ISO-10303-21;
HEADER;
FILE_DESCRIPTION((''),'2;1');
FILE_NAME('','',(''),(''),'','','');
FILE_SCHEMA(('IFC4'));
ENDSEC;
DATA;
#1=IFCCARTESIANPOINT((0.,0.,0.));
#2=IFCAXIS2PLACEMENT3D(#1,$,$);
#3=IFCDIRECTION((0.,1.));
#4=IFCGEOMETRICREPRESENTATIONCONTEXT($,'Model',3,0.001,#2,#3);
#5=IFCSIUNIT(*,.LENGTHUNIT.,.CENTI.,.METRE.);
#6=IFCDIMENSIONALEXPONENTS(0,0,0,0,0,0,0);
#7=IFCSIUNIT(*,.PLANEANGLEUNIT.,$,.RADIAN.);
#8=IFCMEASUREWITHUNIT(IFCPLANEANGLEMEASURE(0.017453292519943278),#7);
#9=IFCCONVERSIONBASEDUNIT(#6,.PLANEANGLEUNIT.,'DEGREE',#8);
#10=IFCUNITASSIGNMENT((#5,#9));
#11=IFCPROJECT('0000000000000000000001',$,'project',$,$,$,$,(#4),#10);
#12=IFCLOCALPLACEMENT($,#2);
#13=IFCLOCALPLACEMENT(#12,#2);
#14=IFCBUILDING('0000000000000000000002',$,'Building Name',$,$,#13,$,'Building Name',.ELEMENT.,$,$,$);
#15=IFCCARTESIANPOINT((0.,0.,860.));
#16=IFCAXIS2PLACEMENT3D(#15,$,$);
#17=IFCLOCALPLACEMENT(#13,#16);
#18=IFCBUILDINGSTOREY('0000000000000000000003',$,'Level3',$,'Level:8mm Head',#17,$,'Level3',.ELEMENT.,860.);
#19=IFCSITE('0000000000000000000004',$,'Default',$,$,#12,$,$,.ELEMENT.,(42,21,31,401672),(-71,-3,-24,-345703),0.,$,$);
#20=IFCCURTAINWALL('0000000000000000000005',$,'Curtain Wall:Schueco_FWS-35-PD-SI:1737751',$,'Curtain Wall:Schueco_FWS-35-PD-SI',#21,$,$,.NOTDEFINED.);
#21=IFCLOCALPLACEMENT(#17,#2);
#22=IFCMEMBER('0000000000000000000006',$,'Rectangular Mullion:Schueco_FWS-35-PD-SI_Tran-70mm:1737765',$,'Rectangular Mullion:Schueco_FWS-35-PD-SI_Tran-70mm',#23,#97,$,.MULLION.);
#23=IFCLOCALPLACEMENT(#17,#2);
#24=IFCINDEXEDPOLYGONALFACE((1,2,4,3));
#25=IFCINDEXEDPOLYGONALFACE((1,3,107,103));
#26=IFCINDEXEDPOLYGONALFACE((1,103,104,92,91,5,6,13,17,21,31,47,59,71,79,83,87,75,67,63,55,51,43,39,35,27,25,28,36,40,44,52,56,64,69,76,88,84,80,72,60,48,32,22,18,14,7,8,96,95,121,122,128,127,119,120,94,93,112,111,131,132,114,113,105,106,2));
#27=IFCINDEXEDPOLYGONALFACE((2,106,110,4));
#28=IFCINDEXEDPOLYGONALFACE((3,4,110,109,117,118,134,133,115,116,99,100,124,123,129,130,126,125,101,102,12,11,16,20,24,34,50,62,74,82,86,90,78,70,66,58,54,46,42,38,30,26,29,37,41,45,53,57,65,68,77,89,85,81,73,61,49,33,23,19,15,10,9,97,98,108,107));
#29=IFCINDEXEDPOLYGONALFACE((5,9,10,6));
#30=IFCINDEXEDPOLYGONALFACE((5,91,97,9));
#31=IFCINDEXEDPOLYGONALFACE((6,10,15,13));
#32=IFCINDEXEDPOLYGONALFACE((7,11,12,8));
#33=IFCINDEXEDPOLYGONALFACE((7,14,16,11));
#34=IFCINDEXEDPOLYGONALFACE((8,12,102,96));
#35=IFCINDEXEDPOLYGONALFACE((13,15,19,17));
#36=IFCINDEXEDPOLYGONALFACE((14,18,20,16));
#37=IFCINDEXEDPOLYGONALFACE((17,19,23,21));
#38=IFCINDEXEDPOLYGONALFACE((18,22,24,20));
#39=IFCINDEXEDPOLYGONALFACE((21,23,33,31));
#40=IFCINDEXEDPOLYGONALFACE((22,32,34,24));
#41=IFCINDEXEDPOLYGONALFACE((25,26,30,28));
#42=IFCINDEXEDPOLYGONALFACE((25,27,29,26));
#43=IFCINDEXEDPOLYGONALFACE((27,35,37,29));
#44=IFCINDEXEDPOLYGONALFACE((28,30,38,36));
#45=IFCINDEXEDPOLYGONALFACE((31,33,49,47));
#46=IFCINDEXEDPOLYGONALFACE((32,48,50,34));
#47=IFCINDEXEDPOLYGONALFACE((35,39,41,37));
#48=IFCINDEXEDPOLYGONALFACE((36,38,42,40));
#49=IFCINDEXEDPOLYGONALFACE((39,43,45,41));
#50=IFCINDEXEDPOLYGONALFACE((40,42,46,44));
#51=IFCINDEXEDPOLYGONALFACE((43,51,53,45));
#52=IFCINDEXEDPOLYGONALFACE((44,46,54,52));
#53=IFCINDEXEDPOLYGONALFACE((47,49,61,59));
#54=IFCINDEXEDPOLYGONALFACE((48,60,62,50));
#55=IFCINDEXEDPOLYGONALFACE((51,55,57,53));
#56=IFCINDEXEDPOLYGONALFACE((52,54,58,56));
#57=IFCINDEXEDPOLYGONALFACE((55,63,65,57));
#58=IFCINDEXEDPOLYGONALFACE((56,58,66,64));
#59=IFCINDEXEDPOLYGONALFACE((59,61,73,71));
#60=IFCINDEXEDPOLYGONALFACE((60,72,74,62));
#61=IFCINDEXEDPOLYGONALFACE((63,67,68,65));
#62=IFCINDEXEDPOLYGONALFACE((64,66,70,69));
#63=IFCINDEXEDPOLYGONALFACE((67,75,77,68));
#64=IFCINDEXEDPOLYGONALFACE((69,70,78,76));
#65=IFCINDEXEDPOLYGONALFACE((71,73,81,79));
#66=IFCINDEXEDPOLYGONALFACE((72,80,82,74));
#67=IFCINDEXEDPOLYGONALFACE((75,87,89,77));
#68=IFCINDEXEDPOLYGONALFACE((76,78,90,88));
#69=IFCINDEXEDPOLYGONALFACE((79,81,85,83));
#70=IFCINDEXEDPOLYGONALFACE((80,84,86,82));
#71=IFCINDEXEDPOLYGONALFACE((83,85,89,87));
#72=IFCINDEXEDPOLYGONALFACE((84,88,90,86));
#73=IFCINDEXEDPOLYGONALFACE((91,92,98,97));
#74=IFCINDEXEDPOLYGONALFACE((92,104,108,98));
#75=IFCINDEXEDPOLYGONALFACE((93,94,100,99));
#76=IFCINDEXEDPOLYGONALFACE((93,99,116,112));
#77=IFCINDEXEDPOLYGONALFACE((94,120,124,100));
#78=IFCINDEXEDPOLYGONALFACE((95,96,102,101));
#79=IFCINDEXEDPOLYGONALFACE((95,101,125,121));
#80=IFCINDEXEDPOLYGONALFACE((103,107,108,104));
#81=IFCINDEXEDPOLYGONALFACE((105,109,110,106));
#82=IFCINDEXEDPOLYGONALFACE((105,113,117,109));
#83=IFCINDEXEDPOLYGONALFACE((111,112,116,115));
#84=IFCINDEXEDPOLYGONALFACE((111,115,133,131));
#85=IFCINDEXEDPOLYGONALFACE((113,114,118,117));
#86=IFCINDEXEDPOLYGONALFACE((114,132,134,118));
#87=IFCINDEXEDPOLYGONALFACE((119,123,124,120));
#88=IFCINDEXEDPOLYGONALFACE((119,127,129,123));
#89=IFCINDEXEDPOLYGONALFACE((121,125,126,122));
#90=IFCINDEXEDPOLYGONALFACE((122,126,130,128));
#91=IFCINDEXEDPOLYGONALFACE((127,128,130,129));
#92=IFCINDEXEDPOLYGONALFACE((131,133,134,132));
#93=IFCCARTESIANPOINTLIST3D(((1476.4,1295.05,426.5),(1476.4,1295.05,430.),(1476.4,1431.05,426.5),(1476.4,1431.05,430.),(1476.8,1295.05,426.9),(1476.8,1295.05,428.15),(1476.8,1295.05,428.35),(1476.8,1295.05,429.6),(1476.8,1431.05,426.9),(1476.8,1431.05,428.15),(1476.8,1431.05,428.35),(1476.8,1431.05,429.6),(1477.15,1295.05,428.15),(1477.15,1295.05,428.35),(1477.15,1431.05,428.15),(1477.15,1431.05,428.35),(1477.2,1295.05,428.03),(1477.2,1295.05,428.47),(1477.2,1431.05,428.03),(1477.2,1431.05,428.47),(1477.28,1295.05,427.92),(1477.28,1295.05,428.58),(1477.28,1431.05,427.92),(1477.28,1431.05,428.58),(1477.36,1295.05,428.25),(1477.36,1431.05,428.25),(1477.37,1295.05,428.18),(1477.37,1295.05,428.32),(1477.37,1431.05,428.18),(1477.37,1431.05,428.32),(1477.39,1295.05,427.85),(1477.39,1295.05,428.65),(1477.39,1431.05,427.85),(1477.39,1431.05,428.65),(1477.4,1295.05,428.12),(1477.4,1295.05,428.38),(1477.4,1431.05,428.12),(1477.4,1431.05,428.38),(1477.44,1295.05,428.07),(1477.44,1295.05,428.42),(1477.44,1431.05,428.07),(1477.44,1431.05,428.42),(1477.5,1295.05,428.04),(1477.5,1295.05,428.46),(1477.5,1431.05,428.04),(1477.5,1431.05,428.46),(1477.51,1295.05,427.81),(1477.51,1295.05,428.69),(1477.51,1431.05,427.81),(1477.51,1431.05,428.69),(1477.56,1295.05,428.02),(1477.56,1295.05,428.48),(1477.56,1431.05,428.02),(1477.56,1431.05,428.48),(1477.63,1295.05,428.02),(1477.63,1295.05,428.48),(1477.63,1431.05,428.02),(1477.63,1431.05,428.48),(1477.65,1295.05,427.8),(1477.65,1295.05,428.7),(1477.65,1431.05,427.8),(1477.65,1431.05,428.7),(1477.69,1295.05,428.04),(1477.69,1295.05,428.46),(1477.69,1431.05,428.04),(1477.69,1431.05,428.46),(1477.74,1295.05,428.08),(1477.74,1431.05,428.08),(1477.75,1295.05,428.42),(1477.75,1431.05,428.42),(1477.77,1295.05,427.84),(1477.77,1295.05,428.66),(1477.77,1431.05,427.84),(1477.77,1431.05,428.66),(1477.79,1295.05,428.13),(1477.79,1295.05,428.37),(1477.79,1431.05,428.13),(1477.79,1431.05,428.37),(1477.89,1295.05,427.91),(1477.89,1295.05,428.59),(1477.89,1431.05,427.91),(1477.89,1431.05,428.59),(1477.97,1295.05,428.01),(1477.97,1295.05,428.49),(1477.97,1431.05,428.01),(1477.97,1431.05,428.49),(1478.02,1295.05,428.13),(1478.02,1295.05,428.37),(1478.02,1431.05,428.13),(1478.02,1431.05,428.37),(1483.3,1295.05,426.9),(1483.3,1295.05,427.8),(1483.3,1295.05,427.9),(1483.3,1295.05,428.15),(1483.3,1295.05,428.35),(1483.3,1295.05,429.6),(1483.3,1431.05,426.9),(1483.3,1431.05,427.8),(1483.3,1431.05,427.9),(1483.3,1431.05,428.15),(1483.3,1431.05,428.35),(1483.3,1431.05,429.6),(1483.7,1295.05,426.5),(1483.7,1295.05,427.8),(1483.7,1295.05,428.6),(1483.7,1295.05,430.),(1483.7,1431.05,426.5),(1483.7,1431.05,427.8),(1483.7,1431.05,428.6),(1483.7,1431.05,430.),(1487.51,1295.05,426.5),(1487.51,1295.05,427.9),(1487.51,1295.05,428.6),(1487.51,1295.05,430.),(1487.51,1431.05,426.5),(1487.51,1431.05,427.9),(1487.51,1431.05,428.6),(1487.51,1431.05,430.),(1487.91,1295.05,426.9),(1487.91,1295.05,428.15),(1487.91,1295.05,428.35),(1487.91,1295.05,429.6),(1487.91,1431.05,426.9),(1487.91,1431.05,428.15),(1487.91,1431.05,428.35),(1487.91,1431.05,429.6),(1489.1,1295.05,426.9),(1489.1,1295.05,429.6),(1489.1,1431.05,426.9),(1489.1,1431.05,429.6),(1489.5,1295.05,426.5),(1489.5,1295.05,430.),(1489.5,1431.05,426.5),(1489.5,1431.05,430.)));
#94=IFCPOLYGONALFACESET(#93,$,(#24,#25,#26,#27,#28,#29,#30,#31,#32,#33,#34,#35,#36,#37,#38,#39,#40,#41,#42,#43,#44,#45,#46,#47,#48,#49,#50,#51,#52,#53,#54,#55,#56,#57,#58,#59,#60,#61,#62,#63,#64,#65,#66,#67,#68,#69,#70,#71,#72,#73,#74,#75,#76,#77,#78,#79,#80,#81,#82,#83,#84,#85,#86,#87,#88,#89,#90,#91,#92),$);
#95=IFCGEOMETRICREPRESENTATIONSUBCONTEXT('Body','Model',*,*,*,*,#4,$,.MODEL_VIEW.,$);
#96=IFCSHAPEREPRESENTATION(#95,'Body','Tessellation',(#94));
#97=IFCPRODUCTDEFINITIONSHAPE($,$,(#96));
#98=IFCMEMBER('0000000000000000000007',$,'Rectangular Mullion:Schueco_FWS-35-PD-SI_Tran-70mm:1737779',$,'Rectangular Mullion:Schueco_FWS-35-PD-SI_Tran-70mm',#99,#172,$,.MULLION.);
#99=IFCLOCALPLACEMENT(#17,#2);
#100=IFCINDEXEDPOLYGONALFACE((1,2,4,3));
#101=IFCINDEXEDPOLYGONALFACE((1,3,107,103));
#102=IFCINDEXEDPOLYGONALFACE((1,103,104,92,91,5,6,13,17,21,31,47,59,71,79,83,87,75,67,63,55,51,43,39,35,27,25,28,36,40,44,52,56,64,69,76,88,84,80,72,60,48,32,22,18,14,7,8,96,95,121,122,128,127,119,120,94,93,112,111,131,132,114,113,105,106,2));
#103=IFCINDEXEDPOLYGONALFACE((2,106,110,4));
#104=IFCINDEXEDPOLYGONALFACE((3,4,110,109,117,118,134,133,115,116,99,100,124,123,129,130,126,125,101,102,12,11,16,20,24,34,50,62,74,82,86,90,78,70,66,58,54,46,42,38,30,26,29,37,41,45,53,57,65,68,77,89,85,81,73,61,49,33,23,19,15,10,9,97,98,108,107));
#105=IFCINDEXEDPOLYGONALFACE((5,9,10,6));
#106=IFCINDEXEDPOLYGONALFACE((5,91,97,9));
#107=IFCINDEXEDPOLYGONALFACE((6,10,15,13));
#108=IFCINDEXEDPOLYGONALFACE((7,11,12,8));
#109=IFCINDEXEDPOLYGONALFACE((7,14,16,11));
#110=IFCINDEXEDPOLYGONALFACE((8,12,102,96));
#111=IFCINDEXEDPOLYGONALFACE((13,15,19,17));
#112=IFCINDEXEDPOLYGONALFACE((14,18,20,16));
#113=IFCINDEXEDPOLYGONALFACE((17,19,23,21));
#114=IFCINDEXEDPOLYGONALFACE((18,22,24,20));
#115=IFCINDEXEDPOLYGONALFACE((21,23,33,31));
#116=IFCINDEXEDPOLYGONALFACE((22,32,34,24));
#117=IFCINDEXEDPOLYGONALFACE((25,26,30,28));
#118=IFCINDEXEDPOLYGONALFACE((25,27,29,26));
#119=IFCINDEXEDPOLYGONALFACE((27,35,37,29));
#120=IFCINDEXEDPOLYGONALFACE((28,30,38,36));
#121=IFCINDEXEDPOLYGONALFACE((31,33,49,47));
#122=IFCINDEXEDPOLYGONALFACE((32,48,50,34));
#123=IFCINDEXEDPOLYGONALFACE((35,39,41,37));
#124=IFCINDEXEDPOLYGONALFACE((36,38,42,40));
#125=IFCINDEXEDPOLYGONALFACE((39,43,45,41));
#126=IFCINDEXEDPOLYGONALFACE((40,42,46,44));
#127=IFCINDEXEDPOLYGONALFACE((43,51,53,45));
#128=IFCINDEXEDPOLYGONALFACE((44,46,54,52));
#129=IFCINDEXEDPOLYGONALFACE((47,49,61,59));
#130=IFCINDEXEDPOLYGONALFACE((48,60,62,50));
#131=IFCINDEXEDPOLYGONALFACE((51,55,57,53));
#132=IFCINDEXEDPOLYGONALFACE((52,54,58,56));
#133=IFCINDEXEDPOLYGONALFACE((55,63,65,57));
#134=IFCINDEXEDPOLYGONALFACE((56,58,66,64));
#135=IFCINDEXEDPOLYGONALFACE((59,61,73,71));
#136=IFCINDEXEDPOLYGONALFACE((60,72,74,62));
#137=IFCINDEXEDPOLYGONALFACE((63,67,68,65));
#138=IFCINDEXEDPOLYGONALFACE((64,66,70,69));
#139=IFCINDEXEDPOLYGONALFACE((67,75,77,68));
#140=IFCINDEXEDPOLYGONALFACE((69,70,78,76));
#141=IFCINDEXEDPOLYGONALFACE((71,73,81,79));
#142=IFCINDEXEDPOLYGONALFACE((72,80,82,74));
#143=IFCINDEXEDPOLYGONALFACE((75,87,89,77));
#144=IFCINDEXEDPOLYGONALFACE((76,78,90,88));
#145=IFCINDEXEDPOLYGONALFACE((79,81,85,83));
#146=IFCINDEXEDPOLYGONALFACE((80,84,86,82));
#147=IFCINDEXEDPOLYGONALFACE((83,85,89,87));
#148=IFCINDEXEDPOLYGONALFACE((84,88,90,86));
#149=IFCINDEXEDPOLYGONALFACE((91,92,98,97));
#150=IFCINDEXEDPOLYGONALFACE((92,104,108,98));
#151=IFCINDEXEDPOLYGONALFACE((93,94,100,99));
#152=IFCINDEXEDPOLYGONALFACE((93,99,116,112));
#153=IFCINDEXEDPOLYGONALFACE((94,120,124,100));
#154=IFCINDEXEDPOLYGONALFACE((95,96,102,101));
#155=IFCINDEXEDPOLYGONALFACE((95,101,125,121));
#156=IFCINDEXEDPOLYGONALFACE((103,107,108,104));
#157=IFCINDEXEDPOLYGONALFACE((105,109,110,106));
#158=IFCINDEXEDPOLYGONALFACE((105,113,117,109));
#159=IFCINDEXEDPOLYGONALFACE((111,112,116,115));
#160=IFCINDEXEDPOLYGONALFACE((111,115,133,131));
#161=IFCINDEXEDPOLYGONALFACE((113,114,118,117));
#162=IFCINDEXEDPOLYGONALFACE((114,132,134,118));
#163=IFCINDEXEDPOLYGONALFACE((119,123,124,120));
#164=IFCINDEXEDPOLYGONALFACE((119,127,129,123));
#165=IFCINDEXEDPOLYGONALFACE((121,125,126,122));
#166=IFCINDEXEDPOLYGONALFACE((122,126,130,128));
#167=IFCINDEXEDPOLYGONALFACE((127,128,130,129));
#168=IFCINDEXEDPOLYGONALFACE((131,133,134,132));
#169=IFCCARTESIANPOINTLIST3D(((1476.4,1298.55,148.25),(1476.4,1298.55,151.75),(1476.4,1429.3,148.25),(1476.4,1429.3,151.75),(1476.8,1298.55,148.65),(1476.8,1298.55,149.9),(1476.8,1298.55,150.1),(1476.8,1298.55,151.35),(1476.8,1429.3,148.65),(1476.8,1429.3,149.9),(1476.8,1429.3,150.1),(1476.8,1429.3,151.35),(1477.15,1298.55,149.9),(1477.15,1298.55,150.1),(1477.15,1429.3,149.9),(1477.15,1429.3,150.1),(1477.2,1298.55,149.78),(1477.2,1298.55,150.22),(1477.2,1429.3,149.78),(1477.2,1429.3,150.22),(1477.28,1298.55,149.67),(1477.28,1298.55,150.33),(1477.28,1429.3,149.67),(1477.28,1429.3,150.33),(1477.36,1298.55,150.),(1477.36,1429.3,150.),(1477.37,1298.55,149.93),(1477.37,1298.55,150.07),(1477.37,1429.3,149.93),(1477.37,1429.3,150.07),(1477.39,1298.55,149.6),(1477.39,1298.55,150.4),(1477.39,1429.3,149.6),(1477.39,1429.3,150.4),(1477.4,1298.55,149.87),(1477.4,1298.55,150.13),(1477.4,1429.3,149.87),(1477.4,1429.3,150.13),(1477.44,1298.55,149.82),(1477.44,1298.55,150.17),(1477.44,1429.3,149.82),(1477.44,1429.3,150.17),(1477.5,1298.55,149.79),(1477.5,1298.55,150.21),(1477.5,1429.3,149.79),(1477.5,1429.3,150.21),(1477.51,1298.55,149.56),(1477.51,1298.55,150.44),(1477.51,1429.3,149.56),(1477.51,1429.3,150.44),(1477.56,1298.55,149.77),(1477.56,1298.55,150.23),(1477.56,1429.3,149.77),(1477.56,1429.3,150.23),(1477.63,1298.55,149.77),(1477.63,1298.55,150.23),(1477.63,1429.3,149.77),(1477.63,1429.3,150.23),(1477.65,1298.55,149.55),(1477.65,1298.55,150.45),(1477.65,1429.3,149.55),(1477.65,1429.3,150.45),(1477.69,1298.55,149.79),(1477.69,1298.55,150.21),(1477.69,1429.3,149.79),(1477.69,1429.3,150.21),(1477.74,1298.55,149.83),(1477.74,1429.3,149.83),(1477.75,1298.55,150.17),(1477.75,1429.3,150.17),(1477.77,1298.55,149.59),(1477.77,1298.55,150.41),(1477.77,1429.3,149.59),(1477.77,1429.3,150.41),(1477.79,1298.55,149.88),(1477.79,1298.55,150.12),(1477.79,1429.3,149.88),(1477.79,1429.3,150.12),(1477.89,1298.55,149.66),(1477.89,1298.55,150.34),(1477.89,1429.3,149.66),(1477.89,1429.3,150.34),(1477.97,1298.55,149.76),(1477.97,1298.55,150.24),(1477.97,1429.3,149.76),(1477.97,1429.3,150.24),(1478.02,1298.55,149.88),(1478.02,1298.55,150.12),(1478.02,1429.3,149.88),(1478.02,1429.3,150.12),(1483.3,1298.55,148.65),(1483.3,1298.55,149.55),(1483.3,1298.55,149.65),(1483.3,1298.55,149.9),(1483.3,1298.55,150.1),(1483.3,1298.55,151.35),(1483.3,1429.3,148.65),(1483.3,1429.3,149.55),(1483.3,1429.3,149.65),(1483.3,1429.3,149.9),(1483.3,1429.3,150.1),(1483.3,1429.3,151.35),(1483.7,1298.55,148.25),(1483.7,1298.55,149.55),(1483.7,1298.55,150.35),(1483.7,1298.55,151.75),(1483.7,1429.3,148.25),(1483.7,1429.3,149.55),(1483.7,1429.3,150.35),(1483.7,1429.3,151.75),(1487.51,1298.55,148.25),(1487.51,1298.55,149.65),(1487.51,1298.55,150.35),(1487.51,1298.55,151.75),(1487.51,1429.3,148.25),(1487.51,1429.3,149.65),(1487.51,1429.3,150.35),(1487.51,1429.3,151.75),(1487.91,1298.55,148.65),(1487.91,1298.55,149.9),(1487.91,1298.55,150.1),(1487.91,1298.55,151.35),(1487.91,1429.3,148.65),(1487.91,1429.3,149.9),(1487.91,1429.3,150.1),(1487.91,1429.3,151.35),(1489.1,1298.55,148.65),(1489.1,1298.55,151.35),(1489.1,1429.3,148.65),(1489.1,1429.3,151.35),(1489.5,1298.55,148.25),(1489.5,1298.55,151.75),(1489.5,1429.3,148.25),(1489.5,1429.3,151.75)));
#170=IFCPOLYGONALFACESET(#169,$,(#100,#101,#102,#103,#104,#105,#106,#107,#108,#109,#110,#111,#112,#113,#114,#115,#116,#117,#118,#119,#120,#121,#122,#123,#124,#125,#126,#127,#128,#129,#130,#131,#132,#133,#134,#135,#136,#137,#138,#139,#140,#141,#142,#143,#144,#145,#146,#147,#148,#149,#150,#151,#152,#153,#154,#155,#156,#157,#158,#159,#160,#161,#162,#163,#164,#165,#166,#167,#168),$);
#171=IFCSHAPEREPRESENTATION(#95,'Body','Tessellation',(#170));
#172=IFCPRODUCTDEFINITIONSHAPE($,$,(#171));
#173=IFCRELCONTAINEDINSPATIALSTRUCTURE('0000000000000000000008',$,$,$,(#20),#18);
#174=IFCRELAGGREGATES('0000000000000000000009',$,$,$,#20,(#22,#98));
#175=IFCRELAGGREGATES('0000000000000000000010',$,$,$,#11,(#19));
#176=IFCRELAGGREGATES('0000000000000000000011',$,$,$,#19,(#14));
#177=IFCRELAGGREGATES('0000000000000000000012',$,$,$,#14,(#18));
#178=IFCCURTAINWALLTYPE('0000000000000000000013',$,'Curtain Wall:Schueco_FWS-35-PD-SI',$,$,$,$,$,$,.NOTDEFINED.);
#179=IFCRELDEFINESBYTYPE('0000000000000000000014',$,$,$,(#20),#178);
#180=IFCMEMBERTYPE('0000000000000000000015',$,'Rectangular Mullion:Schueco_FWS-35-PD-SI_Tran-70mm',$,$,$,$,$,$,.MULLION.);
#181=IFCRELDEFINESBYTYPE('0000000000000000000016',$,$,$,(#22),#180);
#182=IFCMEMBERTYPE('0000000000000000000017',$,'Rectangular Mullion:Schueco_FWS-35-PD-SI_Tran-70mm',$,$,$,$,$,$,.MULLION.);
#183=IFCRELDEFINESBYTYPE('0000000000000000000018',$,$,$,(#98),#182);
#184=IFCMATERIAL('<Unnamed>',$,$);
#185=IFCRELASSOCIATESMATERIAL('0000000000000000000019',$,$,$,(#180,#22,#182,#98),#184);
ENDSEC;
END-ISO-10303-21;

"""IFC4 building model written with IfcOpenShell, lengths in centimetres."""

from ifc_helpers import new_model, entity, si_unit, converted_unit, direction, frame, origin, place, context, subcontext, project, spatial, line, arc, indexed_curve, outline, extrude, source, transform, mapped, material, type_object, type_shapes, element, aggregate, save


model = new_model("IFC4")

# Units and contexts
model_context = context("Model", 3, precision=0.001, world=origin(), true_north=direction((0.0, 1.0)))
body_context = subcontext(model_context, "Body", "Model", "MODEL_VIEW")
ifc_project = project(units=[si_unit("LENGTHUNIT", "METRE", prefix="CENTI"), converted_unit("PLANEANGLEUNIT", "DEGREE", entity("IfcPlaneAngleMeasure", 0.017453292519943278), si_unit("PLANEANGLEUNIT", "RADIAN"), dimensions=[0, 0, 0, 0, 0, 0, 0])], contexts=[model_context])

# Site, building, storey
site_placement = place(None, origin())
site = spatial("IfcSite", under=ifc_project, at=site_placement, Name="Default", CompositionType="ELEMENT", RefLatitude=(42, 21, 31, 401672), RefLongitude=(-71, -3, -24, -345703), RefElevation=0.0)
building_placement = place(site_placement, origin())
building = spatial("IfcBuilding", under=site, at=building_placement, Name="Building Name", LongName="Building Name", CompositionType="ELEMENT")
storey_placement = place(building_placement, frame((0.0, 0.0, 860.0)))
storey = spatial("IfcBuildingStorey", under=building, at=storey_placement, Name="Level3", ObjectType="Level:8mm Head", LongName="Level3", CompositionType="ELEMENT", Elevation=860.0)

# Curtain wall, members
curtain_wall_type = type_object("IfcCurtainWallType", Name="Curtain Wall:Schueco_FWS-35-PD-SI", PredefinedType="NOTDEFINED")
curtain_wall_placement = place(storey_placement, frame((0.0, 0.0, -860.0)))
curtain_wall = element("IfcCurtainWall", 1, at=curtain_wall_placement, inside=storey, type_object=curtain_wall_type, Name="Curtain Wall:Schueco_FWS-35-PD-SI:1737751", ObjectType="Curtain Wall:Schueco_FWS-35-PD-SI", PredefinedType="NOTDEFINED")
ifc_material_1 = material(Name="<Unnamed>")
member_type_1 = type_object("IfcMemberType", Name="Rectangular Mullion:Schueco_FWS-35-PD-SI_Tran-70mm", PredefinedType="MULLION", material=ifc_material_1)
shared_shape_1 = source(origin(), body_context, "Body", "SweptSolid", [
    extrude(outline(indexed_curve([(-1.78, -6.52), (1.72, -6.52), (1.72, 0.78), (0.42, 0.78), (0.42, 0.38), (1.32, 0.38), (1.32, -6.12), (0.07, -6.12), (0.07, -5.77), (0.42, -5.34), (0.09, -4.9), (0.09, -5.14), (-0.03, -5.56), (-0.15, -5.14), (-0.15, -4.9), (-0.48, -5.34), (-0.13, -5.77), (-0.13, -6.12), (-1.38, -6.12), (-1.38, 0.38), (-0.13, 0.38), (-0.13, 4.99), (-1.38, 4.99), (-1.38, 6.18), (1.32, 6.18), (1.32, 4.99), (0.07, 4.99), (0.07, 0.38), (0.32, 0.38), (0.32, 4.59), (1.72, 4.59), (1.72, 6.58), (-1.78, 6.58), (-1.78, 4.59), (-0.38, 4.59), (-0.38, 0.78), (-1.78, 0.78)], segments=[line(1, 2, 3, 4, 5, 6, 7, 8, 9), arc(9, 10, 11), line(11, 12), arc(12, 13, 14), line(14, 15), arc(15, 16, 17), line(17, 18, 19, 20, 21, 22, 23, 24, 25, 26, 27, 28, 29, 30, 31, 32, 33, 34, 35, 36, 37, 1)], self_intersect=False)), frame((-1.78, 4.58, -136.0), z_axis=(0.0, 0.0, 1.0), x_axis=(-1.0, 0.0, 0.0)), (0.0, 0.0, 1.0), 136.0),
])
type_shapes(member_type_1, [shared_shape_1])
member_1_placement = place(curtain_wall_placement, frame((1487.5, 1295.05, 1290.0), z_axis=(0.0, -1.0, 0.0), x_axis=(0.0, 0.0, 1.0)))
member_1 = element("IfcMember", 2, at=member_1_placement, type_object=member_type_1, material=ifc_material_1, Name="Rectangular Mullion:Schueco_FWS-35-PD-SI_Tran-70mm:1737765", ObjectType="Rectangular Mullion:Schueco_FWS-35-PD-SI_Tran-70mm", PredefinedType="MULLION", context=body_context, shape_type="MappedRepresentation", body=[
    mapped(shared_shape_1, transform((0.0, 0.0, 0.0), scale=1.0)),
])
member_type_2 = type_object("IfcMemberType", Name="Rectangular Mullion:Schueco_FWS-35-PD-SI_Tran-70mm", PredefinedType="MULLION", material=ifc_material_1)
shared_shape_2 = source(origin(), body_context, "Body", "SweptSolid", [
    extrude(outline(indexed_curve([(-1.78, -6.52), (1.72, -6.52), (1.72, 0.78), (0.42, 0.78), (0.42, 0.38), (1.32, 0.38), (1.32, -6.12), (0.07, -6.12), (0.07, -5.77), (0.42, -5.34), (0.09, -4.9), (0.09, -5.14), (-0.03, -5.56), (-0.15, -5.14), (-0.15, -4.9), (-0.48, -5.34), (-0.13, -5.77), (-0.13, -6.12), (-1.38, -6.12), (-1.38, 0.38), (-0.13, 0.38), (-0.13, 4.99), (-1.38, 4.99), (-1.38, 6.18), (1.32, 6.18), (1.32, 4.99), (0.07, 4.99), (0.07, 0.38), (0.32, 0.38), (0.32, 4.59), (1.72, 4.59), (1.72, 6.58), (-1.78, 6.58), (-1.78, 4.59), (-0.38, 4.59), (-0.38, 0.78), (-1.78, 0.78)], segments=[line(1, 2, 3, 4, 5, 6, 7, 8, 9), arc(9, 10, 11), line(11, 12), arc(12, 13, 14), line(14, 15), arc(15, 16, 17), line(17, 18, 19, 20, 21, 22, 23, 24, 25, 26, 27, 28, 29, 30, 31, 32, 33, 34, 35, 36, 37, 1)], self_intersect=False)), frame((-0.03, 4.58, -130.75), z_axis=(0.0, 0.0, 1.0), x_axis=(-1.0, 0.0, 0.0)), (0.0, 0.0, 1.0), 130.75),
])
type_shapes(member_type_2, [shared_shape_2])
member_2_placement = place(curtain_wall_placement, frame((1487.5, 1298.55, 1010.0), z_axis=(0.0, -1.0, 0.0), x_axis=(0.0, 0.0, 1.0)))
member_2 = element("IfcMember", 3, at=member_2_placement, type_object=member_type_2, material=ifc_material_1, Name="Rectangular Mullion:Schueco_FWS-35-PD-SI_Tran-70mm:1737779", ObjectType="Rectangular Mullion:Schueco_FWS-35-PD-SI_Tran-70mm", PredefinedType="MULLION", context=body_context, shape_type="MappedRepresentation", body=[
    mapped(shared_shape_2, transform((0.0, 0.0, 0.0), scale=1.0)),
])
aggregate(curtain_wall, [member_1, member_2])

save(model, "model.ifc")
